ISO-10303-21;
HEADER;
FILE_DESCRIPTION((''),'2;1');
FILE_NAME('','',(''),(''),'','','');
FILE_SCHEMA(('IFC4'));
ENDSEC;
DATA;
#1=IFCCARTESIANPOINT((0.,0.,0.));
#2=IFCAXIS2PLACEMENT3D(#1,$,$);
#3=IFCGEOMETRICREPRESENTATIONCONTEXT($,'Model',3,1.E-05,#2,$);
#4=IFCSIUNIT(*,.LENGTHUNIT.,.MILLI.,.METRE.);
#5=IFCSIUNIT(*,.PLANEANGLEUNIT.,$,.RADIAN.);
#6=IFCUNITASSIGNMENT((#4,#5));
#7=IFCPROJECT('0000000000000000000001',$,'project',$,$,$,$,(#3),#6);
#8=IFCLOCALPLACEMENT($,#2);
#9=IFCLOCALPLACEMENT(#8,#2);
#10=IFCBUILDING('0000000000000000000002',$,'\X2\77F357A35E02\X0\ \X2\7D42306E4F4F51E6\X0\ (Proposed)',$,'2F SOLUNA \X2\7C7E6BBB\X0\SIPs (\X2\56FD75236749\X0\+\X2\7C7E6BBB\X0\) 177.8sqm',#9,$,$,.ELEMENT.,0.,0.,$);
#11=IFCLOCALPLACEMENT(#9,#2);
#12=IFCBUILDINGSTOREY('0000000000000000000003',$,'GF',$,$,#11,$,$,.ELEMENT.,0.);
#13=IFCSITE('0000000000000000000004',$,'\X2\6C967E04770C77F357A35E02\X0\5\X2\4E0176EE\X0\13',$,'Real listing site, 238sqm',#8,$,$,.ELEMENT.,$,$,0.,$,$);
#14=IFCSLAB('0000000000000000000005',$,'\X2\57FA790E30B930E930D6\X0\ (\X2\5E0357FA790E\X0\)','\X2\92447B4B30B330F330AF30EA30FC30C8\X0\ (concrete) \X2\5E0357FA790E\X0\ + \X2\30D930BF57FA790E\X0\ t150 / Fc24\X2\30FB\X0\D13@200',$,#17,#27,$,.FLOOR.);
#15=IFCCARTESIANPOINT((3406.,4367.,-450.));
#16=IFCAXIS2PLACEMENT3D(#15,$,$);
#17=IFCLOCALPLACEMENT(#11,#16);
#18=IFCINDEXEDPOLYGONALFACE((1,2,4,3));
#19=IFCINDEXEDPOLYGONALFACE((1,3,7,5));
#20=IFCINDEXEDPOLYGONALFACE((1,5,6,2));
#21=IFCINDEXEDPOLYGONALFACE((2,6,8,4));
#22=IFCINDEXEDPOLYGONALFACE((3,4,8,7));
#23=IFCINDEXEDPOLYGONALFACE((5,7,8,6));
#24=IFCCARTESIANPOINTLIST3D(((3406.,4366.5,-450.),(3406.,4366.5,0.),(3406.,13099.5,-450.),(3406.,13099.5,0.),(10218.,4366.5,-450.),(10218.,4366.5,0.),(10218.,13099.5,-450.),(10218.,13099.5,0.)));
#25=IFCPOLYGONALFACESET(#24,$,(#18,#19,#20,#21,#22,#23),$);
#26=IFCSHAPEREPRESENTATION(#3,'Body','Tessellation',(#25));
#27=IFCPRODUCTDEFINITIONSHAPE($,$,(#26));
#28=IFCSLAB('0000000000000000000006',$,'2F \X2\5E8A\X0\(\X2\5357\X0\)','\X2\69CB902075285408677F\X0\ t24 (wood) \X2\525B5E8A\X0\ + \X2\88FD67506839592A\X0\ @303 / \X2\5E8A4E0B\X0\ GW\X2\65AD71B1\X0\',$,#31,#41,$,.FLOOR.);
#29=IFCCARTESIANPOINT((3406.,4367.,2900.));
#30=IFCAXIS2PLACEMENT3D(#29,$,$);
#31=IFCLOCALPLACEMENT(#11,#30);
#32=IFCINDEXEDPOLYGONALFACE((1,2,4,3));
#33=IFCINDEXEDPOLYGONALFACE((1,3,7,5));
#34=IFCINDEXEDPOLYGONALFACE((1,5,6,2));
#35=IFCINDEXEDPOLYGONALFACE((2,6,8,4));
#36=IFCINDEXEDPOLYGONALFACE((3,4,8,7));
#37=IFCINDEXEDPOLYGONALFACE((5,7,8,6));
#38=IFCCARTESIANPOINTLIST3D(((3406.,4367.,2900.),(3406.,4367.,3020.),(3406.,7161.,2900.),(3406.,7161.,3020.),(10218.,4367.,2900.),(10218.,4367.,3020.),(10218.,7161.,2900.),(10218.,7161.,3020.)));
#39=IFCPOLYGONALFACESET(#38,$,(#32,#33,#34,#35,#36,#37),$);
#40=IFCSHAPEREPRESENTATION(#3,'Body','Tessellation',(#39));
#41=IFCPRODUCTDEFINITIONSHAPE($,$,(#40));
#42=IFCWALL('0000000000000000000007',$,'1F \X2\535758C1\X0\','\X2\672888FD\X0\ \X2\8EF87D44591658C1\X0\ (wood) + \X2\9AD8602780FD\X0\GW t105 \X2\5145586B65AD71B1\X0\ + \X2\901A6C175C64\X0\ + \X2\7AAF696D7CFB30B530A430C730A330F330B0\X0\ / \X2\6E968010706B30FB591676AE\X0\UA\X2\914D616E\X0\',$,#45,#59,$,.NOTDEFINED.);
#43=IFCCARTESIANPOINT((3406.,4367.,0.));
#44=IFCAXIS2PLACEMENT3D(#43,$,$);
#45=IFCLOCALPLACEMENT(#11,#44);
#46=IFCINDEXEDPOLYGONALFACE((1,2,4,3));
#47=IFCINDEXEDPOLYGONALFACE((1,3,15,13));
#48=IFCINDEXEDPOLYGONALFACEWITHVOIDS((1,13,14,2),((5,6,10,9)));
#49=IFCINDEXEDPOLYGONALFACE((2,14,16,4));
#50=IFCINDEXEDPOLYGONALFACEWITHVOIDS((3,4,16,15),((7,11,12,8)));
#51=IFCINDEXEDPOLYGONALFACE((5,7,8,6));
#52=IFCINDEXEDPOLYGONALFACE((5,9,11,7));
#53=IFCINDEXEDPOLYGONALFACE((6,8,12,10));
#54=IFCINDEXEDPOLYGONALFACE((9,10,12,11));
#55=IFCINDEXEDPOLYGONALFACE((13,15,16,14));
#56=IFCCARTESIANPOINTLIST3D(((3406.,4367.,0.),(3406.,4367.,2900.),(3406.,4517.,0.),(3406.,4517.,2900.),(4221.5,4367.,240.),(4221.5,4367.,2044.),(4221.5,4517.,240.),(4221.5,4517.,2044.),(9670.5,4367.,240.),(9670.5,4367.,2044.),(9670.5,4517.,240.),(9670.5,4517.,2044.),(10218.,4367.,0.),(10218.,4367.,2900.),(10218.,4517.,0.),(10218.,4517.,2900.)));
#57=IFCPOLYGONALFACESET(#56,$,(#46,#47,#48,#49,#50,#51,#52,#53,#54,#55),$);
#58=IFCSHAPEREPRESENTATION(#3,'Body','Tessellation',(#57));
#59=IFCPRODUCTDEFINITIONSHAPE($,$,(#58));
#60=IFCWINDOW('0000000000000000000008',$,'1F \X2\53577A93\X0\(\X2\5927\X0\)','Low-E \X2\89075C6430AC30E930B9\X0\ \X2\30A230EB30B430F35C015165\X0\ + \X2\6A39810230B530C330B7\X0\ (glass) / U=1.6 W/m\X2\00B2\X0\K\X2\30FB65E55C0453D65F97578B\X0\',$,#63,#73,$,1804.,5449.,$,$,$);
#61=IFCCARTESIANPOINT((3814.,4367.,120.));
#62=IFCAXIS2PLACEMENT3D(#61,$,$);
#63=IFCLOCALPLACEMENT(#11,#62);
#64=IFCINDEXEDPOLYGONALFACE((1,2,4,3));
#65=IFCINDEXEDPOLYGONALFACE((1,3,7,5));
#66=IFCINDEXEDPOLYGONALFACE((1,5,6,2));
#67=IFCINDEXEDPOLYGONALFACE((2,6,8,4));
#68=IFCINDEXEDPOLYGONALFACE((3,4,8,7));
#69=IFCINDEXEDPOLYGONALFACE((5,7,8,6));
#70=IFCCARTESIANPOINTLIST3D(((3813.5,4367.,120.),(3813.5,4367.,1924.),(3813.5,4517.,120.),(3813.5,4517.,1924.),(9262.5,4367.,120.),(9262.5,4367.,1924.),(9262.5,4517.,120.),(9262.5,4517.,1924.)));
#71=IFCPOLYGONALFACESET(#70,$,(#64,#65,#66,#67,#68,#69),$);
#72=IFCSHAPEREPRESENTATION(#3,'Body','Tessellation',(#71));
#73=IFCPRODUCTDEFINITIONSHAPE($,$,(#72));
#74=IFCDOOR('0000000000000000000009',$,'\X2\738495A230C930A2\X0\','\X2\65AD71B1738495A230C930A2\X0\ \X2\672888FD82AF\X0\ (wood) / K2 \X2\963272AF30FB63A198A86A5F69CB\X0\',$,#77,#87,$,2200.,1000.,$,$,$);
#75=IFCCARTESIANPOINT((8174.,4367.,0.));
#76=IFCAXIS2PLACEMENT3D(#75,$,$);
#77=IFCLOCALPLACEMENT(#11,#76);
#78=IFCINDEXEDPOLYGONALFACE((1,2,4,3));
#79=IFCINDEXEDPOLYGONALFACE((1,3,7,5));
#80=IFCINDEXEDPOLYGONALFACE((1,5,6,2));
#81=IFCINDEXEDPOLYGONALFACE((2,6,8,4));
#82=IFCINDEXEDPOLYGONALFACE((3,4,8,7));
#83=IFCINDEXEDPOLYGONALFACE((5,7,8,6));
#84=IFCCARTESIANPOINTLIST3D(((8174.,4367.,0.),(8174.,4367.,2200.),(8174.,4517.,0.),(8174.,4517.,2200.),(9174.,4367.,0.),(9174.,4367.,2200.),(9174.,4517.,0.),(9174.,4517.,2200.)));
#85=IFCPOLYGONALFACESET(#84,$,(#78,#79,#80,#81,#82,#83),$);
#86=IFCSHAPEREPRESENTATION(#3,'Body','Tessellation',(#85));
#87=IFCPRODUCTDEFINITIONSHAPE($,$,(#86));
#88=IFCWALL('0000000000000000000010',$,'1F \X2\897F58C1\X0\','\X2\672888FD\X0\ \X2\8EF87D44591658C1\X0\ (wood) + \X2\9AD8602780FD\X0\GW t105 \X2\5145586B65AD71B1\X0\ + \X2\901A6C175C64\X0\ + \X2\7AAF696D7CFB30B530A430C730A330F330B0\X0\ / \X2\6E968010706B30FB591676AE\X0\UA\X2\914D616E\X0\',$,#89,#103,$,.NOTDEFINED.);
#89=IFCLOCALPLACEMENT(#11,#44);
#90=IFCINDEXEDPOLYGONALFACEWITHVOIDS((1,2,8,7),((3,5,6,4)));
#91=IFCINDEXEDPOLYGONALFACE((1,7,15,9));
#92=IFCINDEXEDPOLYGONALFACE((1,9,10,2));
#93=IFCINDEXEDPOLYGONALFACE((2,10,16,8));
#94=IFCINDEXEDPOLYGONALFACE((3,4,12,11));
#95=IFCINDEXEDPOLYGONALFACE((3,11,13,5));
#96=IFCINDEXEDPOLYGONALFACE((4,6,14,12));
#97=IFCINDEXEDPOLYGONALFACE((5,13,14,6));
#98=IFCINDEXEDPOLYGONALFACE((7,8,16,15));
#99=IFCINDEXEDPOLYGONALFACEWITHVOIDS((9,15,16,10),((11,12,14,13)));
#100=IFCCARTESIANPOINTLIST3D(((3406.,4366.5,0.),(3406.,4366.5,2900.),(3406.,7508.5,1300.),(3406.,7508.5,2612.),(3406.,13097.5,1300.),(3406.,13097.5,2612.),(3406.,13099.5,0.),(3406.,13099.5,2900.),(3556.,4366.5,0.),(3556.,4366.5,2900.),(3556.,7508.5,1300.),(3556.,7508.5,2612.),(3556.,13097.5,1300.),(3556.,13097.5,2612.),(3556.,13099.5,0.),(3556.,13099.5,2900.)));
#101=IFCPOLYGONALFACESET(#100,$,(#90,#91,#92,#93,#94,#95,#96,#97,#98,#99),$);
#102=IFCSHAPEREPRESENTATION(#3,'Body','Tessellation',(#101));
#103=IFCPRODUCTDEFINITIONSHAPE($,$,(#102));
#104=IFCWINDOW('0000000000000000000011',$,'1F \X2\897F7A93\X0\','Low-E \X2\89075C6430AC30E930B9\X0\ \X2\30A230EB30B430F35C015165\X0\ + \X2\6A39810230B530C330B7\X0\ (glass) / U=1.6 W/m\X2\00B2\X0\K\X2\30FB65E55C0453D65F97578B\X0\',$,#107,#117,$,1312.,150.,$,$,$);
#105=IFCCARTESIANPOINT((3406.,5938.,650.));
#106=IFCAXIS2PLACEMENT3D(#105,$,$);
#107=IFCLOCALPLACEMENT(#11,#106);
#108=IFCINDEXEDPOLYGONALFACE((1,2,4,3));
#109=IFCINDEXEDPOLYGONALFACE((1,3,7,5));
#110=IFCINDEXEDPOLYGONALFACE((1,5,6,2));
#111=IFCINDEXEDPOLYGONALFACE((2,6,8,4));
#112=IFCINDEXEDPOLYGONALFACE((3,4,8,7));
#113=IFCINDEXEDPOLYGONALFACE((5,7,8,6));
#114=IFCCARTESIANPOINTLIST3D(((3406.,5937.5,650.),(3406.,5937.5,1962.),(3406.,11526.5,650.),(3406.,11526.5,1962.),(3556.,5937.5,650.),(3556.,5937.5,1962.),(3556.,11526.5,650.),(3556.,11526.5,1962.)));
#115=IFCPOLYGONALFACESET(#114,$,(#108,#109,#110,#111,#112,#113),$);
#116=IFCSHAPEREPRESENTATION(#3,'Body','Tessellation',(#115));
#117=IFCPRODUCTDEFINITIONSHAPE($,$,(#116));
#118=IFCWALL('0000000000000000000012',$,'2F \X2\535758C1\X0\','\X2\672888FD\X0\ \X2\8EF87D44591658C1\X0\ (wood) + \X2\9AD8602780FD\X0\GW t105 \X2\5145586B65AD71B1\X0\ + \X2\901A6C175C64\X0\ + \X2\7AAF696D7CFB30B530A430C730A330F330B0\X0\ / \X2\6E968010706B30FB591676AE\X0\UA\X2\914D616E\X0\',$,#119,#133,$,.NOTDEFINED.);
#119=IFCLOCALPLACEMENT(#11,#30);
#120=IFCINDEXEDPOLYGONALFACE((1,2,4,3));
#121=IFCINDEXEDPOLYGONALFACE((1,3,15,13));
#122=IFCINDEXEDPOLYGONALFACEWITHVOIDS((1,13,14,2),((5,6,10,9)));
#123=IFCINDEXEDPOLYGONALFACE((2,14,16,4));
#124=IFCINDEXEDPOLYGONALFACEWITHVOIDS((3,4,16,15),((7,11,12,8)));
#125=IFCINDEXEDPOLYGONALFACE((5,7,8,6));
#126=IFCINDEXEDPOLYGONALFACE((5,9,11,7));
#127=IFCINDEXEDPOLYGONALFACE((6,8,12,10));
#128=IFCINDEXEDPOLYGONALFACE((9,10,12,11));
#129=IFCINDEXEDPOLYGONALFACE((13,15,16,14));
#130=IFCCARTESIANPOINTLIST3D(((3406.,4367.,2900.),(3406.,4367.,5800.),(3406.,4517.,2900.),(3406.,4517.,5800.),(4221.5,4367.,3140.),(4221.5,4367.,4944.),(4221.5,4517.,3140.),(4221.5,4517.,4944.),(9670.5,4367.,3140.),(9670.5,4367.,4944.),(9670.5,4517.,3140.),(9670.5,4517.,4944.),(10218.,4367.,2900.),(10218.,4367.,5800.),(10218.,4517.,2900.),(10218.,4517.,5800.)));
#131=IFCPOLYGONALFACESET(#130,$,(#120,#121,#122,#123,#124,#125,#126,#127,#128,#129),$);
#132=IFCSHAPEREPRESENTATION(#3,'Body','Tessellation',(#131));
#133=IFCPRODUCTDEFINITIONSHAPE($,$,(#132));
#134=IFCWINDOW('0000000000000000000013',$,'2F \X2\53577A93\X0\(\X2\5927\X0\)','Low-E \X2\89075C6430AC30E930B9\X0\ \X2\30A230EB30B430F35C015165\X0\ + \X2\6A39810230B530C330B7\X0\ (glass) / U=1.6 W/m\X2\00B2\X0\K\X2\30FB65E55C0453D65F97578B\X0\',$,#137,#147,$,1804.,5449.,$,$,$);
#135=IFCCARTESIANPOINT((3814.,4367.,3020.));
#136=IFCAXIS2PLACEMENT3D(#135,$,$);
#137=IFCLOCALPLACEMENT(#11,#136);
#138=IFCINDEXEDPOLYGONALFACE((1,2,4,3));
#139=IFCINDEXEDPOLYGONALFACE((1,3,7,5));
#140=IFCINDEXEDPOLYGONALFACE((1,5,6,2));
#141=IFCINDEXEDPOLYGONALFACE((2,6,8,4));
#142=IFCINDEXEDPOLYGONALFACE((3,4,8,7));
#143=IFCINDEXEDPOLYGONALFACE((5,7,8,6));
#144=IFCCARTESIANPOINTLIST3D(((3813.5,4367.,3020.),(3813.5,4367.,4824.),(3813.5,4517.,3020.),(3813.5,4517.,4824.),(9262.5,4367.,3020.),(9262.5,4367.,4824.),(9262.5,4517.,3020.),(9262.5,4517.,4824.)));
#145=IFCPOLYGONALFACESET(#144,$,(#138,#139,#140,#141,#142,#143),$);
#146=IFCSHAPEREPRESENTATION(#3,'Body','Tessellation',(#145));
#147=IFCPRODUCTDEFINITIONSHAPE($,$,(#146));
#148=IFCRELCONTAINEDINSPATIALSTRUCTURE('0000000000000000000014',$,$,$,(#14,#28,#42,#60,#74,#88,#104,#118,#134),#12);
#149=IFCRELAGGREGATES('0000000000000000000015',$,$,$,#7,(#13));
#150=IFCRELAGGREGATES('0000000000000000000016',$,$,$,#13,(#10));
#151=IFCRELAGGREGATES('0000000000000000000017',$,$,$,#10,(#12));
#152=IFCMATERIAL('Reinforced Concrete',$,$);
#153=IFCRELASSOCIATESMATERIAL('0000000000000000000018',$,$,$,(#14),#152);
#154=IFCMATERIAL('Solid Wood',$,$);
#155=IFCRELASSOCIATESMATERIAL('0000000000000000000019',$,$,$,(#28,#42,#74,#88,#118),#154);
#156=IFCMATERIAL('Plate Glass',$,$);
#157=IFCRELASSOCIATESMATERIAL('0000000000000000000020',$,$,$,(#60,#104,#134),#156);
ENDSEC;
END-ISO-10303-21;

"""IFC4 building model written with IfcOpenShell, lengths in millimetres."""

from ifc_helpers import new_model, si_unit, frame, frame_2d, origin, place, context, project, spatial, rectangle, extrude, material, element, fill, save


model = new_model("IFC4")

# Units and contexts
model_context = context("Model", 3, precision=1e-05, world=origin())
ifc_project = project(units=[si_unit("LENGTHUNIT", "METRE", prefix="MILLI"), si_unit("PLANEANGLEUNIT", "RADIAN")], contexts=[model_context])

# Site, building, storey
site_placement = place(None, origin())
site = spatial("IfcSite", under=ifc_project, at=site_placement, Name="沖縄県石垣市5丁目13", ObjectType="Real listing site, 238sqm", CompositionType="ELEMENT", RefElevation=0.0)
building_placement = place(site_placement, origin())
building = spatial("IfcBuilding", under=site, at=building_placement, Name="石垣市 終の住処 (Proposed)", ObjectType="2F SOLUNA 籾殻SIPs (国産杉+籾殻) 177.8sqm", CompositionType="ELEMENT", ElevationOfRefHeight=0.0, ElevationOfTerrain=0.0)
storey_placement = place(building_placement, origin())
storey = spatial("IfcBuildingStorey", under=building, at=storey_placement, Name="GF", CompositionType="ELEMENT", Elevation=0.0)

# Slabs
ifc_material_1 = material(Name="Reinforced Concrete")
slab_1_placement = place(storey_placement, frame((3406.0, 4367.0, -450.0)))
element("IfcSlab", 1, at=slab_1_placement, inside=storey, material=ifc_material_1, Name="基礎スラブ (布基礎)", Description="鉄筋コンクリート (concrete) 布基礎 + ベタ基礎 t150 / Fc24・D13@200", PredefinedType="FLOOR", context=model_context, shape_type="SweptSolid", body=[
    extrude(rectangle(XDim=6812.0, YDim=8733.0, at=frame_2d((3406.0, 4366.0))), frame((3406.0, 4367.0, -450.0)), (0.0, 0.0, 1.0), 450.0),
])
ifc_material_2 = material(Name="Solid Wood")
slab_2_placement = place(storey_placement, frame((3406.0, 4367.0, 2900.0)))
element("IfcSlab", 2, at=slab_2_placement, inside=storey, material=ifc_material_2, Name="2F 床(南)", Description="構造用合板 t24 (wood) 剛床 + 製材根太 @303 / 床下 GW断熱", PredefinedType="FLOOR", context=model_context, shape_type="SweptSolid", body=[
    extrude(rectangle(XDim=6812.0, YDim=2794.0, at=frame_2d((3406.0, 1397.0))), frame((3406.0, 4367.0, 2900.0)), (0.0, 0.0, 1.0), 120.0),
])

# Wall, openings, window, door
wall_1_placement = place(storey_placement, frame((3406.0, 4367.0, 0.0)))
wall_1 = element("IfcWall", 3, at=wall_1_placement, inside=storey, material=ifc_material_2, Name="1F 南壁", Description="木製 軸組外壁 (wood) + 高性能GW t105 充填断熱 + 通気層 + 窯業系サイディング / 準耐火・外皮UA配慮", PredefinedType="NOTDEFINED", context=model_context, shape_type="SweptSolid", body=[
    extrude(rectangle(XDim=6812.0, YDim=150.0, at=frame_2d((3406.0, 75.0))), frame((3406.0, 4367.0, 0.0)), (0.0, 0.0, 1.0), 2900.0),
])
opening_1_placement = place(storey_placement, frame((3814.0, 4367.0, 120.0)))
opening_1 = element("IfcOpeningElement", 4, at=opening_1_placement, cuts=wall_1, PredefinedType="NOTDEFINED", context=model_context, shape_type="SweptSolid", body=[
    extrude(rectangle(XDim=5449.0, YDim=150.0, at=frame_2d((2724.0, 75.0))), frame((3814.0, 4367.0, 120.0)), (0.0, 0.0, 1.0), 1804.0),
])
opening_2_placement = place(storey_placement, frame((8174.0, 4367.0, 0.0)))
opening_2 = element("IfcOpeningElement", 5, at=opening_2_placement, cuts=wall_1, PredefinedType="NOTDEFINED", context=model_context, shape_type="SweptSolid", body=[
    extrude(rectangle(XDim=1000.0, YDim=150.0, at=frame_2d((500.0, 75.0))), frame((8174.0, 4367.0, 0.0)), (0.0, 0.0, 1.0), 2200.0),
])
ifc_material_3 = material(Name="Plate Glass")
window_1_placement = place(storey_placement, frame((3814.0, 4367.0, 120.0)))
window_1 = element("IfcWindow", 6, at=window_1_placement, inside=storey, material=ifc_material_3, Name="1F 南窓(大)", Description="Low-E 複層ガラス アルゴン封入 + 樹脂サッシ (glass) / U=1.6 W/m²K・日射取得型", OverallHeight=1804.0, OverallWidth=5449.0, context=model_context, shape_type="SweptSolid", body=[
    extrude(rectangle(XDim=5449.0, YDim=150.0, at=frame_2d((2724.0, 75.0))), frame((3814.0, 4367.0, 120.0)), (0.0, 0.0, 1.0), 1804.0),
])
fill(opening_1, window_1)
door_placement = place(storey_placement, frame((8174.0, 4367.0, 0.0)))
door = element("IfcDoor", 7, at=door_placement, inside=storey, material=ifc_material_2, Name="玄関ドア", Description="断熱玄関ドア 木製芯 (wood) / K2 防犯・採風機構", OverallHeight=2200.0, OverallWidth=1000.0, context=model_context, shape_type="SweptSolid", body=[
    extrude(rectangle(XDim=1000.0, YDim=150.0, at=frame_2d((500.0, 75.0))), frame((8174.0, 4367.0, 0.0)), (0.0, 0.0, 1.0), 2200.0),
])
fill(opening_2, door)

# Walls, openings, windows
wall_2_placement = place(storey_placement, frame((3406.0, 4367.0, 0.0)))
wall_2 = element("IfcWall", 8, at=wall_2_placement, inside=storey, material=ifc_material_2, Name="1F 西壁", Description="木製 軸組外壁 (wood) + 高性能GW t105 充填断熱 + 通気層 + 窯業系サイディング / 準耐火・外皮UA配慮", PredefinedType="NOTDEFINED", context=model_context, shape_type="SweptSolid", body=[
    extrude(rectangle(XDim=150.0, YDim=8733.0, at=frame_2d((75.0, 4366.0))), frame((3406.0, 4367.0, 0.0)), (0.0, 0.0, 1.0), 2900.0),
])
opening_3_placement = place(storey_placement, frame((3406.0, 5938.0, 650.0)))
opening_3 = element("IfcOpeningElement", 9, at=opening_3_placement, cuts=wall_2, PredefinedType="NOTDEFINED", context=model_context, shape_type="SweptSolid", body=[
    extrude(rectangle(XDim=150.0, YDim=5589.0, at=frame_2d((75.0, 2794.0))), frame((3406.0, 5938.0, 650.0)), (0.0, 0.0, 1.0), 1312.0),
])
window_2_placement = place(storey_placement, frame((3406.0, 5938.0, 650.0)))
window_2 = element("IfcWindow", 10, at=window_2_placement, inside=storey, material=ifc_material_3, Name="1F 西窓", Description="Low-E 複層ガラス アルゴン封入 + 樹脂サッシ (glass) / U=1.6 W/m²K・日射取得型", OverallHeight=1312.0, OverallWidth=150.0, context=model_context, shape_type="SweptSolid", body=[
    extrude(rectangle(XDim=150.0, YDim=5589.0, at=frame_2d((75.0, 2794.0))), frame((3406.0, 5938.0, 650.0)), (0.0, 0.0, 1.0), 1312.0),
])
fill(opening_3, window_2)
wall_3_placement = place(storey_placement, frame((3406.0, 4367.0, 2900.0)))
wall_3 = element("IfcWall", 11, at=wall_3_placement, inside=storey, material=ifc_material_2, Name="2F 南壁", Description="木製 軸組外壁 (wood) + 高性能GW t105 充填断熱 + 通気層 + 窯業系サイディング / 準耐火・外皮UA配慮", PredefinedType="NOTDEFINED", context=model_context, shape_type="SweptSolid", body=[
    extrude(rectangle(XDim=6812.0, YDim=150.0, at=frame_2d((3406.0, 75.0))), frame((3406.0, 4367.0, 2900.0)), (0.0, 0.0, 1.0), 2900.0),
])
opening_4_placement = place(storey_placement, frame((3814.0, 4367.0, 3020.0)))
opening_4 = element("IfcOpeningElement", 12, at=opening_4_placement, cuts=wall_3, PredefinedType="NOTDEFINED", context=model_context, shape_type="SweptSolid", body=[
    extrude(rectangle(XDim=5449.0, YDim=150.0, at=frame_2d((2724.0, 75.0))), frame((3814.0, 4367.0, 3020.0)), (0.0, 0.0, 1.0), 1804.0),
])
window_3_placement = place(storey_placement, frame((3814.0, 4367.0, 3020.0)))
window_3 = element("IfcWindow", 13, at=window_3_placement, inside=storey, material=ifc_material_3, Name="2F 南窓(大)", Description="Low-E 複層ガラス アルゴン封入 + 樹脂サッシ (glass) / U=1.6 W/m²K・日射取得型", OverallHeight=1804.0, OverallWidth=5449.0, context=model_context, shape_type="SweptSolid", body=[
    extrude(rectangle(XDim=5449.0, YDim=150.0, at=frame_2d((2724.0, 75.0))), frame((3814.0, 4367.0, 3020.0)), (0.0, 0.0, 1.0), 1804.0),
])
fill(opening_4, window_3)

save(model, "model.ifc")
